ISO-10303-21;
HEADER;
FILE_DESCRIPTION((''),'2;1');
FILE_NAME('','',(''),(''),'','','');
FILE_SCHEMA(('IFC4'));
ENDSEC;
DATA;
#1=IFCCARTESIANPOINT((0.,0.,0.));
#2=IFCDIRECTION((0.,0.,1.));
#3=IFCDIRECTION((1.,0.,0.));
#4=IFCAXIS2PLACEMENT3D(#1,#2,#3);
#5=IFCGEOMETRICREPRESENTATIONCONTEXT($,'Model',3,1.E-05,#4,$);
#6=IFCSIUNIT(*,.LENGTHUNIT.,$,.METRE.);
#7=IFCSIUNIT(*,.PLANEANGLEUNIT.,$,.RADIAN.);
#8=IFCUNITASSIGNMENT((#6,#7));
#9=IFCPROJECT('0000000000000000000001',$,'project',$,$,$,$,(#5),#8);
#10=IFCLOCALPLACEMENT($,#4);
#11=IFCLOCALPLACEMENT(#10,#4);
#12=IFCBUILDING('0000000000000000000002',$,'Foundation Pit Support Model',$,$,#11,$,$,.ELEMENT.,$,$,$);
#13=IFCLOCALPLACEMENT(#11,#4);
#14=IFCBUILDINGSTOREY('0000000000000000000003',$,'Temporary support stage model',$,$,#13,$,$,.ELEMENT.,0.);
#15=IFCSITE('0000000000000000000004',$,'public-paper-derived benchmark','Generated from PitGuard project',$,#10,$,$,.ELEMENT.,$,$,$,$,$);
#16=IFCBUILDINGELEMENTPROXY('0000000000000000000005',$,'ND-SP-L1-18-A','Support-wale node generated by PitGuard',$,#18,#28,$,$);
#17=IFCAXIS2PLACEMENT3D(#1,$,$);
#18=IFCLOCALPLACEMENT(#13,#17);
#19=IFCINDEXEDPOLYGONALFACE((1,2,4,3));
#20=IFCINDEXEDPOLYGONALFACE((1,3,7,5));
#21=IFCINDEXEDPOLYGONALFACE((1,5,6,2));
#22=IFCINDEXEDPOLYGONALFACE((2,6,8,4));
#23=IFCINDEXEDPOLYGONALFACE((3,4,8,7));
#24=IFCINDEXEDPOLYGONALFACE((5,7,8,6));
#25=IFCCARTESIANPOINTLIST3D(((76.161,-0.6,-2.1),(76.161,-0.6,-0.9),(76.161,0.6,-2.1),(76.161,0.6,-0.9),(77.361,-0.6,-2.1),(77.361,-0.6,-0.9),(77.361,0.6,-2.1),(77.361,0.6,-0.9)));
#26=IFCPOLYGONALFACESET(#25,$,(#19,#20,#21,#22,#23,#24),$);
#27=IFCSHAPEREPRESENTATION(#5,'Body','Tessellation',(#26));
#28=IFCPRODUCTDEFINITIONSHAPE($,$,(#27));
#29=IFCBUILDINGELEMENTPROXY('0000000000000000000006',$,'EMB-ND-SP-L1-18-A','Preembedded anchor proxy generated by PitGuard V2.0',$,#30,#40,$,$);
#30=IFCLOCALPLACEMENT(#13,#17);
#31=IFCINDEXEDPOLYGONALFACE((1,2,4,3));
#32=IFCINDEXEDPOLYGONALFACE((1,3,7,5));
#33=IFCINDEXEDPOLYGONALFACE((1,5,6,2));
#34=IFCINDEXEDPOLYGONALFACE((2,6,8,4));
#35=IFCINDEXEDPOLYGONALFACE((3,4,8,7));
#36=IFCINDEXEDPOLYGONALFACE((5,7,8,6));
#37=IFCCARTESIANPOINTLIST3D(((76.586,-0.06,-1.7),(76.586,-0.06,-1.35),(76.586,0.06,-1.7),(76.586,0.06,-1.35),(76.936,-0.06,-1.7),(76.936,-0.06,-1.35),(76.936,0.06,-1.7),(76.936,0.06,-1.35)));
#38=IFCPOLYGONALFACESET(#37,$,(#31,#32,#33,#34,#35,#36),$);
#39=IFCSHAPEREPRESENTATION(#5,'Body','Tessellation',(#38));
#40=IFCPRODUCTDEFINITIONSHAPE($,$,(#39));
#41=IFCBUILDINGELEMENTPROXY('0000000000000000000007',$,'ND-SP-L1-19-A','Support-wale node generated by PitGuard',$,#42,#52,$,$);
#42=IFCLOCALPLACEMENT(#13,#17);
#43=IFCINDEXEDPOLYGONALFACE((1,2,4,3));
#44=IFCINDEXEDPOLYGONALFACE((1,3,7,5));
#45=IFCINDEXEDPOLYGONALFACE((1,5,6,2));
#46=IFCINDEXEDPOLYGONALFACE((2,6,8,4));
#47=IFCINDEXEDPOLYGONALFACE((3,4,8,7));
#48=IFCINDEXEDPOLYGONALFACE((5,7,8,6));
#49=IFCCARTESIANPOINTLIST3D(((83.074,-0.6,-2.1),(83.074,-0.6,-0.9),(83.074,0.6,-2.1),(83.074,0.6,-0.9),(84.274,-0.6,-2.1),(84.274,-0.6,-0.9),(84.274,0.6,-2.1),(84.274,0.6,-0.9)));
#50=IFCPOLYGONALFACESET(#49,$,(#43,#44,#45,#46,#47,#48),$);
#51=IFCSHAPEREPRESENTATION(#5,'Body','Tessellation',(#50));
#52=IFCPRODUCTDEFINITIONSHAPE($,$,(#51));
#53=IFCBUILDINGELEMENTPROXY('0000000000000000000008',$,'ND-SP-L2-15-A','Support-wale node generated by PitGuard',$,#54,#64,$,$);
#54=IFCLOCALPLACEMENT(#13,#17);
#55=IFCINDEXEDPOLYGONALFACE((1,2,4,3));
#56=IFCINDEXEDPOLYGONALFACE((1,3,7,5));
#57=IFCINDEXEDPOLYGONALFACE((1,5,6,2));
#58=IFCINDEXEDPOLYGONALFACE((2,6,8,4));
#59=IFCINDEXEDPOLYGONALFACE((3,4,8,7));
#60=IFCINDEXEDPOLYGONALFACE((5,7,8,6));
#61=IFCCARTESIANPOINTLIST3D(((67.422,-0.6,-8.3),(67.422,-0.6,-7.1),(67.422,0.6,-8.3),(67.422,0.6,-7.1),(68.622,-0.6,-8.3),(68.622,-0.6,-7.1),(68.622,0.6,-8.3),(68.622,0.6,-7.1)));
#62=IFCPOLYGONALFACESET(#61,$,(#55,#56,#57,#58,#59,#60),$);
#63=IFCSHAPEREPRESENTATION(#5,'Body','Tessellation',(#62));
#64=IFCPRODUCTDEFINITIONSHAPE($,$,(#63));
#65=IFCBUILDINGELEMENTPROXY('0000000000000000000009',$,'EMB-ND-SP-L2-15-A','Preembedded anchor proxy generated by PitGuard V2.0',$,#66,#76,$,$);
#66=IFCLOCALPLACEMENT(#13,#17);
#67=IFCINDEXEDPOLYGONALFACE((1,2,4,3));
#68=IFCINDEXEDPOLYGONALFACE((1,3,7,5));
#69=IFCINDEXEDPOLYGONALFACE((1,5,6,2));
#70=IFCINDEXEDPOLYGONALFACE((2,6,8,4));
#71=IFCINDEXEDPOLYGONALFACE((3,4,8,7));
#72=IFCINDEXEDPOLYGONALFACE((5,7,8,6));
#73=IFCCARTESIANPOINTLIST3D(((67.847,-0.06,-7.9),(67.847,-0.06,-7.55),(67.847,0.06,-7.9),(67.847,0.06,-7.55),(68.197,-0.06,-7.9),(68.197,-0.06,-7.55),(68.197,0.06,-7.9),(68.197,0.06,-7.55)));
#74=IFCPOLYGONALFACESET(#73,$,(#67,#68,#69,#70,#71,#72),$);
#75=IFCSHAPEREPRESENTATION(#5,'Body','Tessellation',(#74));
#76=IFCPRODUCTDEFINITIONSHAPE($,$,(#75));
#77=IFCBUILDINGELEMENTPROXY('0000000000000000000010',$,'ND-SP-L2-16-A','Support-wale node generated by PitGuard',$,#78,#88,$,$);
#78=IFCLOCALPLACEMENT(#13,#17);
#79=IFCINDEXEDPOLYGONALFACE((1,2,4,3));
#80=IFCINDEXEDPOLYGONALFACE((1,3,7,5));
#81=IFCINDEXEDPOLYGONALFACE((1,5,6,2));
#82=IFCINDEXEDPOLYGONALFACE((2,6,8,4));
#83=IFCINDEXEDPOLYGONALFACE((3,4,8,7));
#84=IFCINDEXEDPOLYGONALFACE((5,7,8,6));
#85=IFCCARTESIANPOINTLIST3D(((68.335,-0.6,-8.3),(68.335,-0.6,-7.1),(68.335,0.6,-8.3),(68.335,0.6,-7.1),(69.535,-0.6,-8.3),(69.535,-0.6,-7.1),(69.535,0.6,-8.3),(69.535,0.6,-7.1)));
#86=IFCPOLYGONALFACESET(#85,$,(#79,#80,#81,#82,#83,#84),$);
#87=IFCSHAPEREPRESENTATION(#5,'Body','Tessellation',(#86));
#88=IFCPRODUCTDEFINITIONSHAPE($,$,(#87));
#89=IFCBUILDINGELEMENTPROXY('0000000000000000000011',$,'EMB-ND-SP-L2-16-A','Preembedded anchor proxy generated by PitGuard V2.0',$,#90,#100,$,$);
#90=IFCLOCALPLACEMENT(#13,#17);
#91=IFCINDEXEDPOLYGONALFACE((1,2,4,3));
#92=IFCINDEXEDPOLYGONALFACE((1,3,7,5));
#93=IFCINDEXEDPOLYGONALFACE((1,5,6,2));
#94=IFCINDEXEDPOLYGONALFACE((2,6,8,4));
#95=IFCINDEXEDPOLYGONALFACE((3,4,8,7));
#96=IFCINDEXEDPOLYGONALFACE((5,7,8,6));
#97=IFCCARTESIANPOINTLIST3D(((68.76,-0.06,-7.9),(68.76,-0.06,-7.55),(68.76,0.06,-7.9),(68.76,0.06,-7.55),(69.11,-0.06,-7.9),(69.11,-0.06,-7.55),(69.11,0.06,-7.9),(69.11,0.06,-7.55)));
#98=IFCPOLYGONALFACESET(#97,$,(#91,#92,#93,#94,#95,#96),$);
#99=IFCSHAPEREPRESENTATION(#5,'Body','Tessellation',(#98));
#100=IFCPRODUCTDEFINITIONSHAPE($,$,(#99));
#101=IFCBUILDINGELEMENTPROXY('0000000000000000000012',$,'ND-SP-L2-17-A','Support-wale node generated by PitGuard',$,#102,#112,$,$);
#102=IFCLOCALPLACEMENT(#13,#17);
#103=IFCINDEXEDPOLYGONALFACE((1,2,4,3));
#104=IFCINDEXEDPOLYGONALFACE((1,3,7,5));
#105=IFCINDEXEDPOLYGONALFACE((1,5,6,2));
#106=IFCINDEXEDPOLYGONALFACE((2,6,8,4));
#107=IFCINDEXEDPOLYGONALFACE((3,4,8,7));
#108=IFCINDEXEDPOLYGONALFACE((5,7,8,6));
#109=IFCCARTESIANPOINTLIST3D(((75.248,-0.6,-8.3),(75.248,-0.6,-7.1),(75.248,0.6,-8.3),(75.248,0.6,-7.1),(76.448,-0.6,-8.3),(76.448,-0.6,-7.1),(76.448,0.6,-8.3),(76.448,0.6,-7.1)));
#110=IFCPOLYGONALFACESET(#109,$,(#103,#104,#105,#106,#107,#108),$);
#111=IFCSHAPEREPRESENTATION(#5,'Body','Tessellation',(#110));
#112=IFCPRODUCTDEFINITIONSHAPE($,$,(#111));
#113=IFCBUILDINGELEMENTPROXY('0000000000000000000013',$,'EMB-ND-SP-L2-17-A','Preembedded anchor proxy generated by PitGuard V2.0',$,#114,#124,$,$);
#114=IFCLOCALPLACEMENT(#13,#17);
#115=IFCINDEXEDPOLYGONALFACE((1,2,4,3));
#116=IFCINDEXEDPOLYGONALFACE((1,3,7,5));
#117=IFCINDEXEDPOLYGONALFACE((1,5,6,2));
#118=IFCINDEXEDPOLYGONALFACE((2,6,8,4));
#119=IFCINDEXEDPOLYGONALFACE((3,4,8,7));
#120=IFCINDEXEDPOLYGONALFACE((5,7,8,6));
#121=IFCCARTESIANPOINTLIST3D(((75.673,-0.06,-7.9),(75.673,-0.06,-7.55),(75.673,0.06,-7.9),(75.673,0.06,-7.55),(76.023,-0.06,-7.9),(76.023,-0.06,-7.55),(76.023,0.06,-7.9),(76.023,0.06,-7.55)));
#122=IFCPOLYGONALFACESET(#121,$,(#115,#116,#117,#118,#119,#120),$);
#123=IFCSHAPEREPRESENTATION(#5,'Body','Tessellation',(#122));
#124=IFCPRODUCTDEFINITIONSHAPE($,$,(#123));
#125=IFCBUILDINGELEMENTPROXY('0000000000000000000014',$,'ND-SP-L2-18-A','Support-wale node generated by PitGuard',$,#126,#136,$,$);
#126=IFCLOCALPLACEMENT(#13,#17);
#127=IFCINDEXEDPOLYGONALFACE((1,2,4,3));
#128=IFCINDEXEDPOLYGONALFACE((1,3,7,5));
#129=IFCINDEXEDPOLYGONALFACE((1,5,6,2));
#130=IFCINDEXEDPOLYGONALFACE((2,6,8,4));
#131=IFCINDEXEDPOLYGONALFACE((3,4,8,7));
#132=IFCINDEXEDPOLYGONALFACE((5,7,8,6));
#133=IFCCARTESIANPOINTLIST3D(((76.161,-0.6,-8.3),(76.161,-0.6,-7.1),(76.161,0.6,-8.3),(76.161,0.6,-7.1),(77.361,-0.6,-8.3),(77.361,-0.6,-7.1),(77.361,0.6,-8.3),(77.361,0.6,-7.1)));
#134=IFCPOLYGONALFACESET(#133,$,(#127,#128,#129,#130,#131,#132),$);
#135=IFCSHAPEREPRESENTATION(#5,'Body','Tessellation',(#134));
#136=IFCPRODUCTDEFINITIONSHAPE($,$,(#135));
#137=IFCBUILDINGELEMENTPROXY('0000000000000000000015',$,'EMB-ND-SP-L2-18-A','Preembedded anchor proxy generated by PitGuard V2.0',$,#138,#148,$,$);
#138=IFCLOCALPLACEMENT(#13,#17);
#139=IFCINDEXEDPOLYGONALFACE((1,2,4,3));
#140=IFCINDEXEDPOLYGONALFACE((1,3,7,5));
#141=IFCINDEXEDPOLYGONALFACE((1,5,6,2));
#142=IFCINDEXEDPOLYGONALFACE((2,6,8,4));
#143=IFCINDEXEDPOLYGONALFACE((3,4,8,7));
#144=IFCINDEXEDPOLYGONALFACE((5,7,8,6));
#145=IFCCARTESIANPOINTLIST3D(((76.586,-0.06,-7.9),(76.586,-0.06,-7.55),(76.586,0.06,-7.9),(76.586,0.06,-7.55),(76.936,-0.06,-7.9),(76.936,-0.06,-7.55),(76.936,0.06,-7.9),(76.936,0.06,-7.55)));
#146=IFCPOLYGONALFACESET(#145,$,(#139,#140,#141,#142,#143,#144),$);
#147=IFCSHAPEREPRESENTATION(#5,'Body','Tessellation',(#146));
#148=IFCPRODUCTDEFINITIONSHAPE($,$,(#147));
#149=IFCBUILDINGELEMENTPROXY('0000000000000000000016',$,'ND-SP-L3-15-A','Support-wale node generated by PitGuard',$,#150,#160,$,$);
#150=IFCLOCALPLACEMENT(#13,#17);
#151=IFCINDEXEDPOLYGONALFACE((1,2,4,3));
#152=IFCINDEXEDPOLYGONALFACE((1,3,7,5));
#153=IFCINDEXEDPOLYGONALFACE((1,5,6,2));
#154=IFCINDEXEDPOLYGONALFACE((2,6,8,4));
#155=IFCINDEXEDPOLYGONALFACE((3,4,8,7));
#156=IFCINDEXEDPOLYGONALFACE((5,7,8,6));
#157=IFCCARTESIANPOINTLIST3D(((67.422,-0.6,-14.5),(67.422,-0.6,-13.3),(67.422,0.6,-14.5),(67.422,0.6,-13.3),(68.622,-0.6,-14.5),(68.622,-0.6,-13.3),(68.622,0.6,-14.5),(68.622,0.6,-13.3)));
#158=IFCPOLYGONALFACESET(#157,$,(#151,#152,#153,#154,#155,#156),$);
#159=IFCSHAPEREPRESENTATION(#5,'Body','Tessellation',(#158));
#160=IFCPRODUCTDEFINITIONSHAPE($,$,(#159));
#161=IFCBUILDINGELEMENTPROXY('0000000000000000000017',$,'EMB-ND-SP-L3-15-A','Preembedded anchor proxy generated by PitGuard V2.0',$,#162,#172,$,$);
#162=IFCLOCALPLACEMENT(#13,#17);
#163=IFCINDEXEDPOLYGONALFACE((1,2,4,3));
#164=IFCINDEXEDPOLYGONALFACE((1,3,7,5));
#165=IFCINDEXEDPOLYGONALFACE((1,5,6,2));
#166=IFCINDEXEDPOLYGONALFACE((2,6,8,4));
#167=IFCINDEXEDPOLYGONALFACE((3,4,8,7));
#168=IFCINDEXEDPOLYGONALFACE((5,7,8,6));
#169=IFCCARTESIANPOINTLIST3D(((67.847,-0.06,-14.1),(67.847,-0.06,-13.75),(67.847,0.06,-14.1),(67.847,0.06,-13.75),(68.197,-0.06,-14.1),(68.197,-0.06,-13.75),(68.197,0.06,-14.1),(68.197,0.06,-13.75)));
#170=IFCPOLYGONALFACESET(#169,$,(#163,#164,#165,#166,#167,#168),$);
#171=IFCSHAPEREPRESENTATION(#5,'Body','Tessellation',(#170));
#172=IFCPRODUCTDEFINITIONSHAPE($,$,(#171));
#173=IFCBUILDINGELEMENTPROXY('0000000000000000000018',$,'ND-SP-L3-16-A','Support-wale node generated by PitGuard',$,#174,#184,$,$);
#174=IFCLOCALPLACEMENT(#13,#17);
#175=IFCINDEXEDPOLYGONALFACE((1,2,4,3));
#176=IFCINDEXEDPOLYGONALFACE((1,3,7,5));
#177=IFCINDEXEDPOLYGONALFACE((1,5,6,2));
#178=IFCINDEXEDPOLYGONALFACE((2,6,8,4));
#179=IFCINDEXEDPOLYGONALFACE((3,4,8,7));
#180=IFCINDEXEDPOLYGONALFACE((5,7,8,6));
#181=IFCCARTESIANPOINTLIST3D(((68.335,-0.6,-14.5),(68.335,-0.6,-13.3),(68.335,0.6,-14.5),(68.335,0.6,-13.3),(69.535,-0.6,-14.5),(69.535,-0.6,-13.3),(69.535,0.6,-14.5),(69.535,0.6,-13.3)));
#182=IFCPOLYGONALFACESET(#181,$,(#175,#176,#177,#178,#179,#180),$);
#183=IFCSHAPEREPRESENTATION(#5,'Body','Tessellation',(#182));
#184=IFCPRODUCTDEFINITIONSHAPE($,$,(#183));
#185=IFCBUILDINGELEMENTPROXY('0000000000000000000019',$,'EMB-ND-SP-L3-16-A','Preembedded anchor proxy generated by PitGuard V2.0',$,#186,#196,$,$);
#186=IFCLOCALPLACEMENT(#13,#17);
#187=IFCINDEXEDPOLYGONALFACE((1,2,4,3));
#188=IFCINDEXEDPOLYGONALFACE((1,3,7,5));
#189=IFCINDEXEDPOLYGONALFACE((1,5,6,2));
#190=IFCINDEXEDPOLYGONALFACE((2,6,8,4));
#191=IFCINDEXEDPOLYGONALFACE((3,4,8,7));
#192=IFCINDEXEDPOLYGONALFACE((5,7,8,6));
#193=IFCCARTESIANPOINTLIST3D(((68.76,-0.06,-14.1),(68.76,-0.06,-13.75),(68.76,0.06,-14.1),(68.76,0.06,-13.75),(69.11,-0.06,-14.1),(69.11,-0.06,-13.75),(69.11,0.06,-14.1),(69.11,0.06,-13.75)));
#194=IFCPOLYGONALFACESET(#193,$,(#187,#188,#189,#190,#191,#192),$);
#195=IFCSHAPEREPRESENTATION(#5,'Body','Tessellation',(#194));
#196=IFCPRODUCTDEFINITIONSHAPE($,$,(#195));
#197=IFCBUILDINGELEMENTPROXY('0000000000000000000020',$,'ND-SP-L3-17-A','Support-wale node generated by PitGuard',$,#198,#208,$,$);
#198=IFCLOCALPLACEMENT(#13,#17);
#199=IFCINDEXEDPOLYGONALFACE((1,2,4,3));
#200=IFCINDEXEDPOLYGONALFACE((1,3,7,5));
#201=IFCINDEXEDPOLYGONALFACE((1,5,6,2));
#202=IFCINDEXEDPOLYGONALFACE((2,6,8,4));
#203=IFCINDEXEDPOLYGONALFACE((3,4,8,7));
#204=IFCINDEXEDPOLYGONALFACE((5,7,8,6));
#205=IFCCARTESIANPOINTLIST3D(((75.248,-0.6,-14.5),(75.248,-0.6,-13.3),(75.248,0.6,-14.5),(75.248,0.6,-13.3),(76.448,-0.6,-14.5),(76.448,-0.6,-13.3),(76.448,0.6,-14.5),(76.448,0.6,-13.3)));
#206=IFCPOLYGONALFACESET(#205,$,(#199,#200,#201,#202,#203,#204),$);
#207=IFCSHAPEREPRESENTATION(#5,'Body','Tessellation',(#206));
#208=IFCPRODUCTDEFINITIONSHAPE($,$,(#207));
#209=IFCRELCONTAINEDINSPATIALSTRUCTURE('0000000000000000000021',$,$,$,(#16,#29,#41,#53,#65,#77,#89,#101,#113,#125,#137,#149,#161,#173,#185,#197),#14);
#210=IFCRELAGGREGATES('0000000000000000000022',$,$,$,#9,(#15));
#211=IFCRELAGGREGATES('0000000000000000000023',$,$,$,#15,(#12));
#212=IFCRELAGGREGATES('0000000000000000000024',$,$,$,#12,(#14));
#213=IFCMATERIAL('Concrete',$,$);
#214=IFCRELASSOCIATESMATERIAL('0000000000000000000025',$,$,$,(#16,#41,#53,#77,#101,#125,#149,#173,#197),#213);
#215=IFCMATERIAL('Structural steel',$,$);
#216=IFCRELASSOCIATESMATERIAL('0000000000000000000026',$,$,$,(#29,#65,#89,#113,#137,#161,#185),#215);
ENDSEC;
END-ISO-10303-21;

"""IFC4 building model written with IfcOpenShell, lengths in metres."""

from ifc_helpers import new_model, si_unit, frame, origin_with_axes, origin_2d, place, context, project, spatial, rectangle, extrude, material, element, save


model = new_model("IFC4")

# Units and contexts
model_context = context("Model", 3, precision=1e-05, world=origin_with_axes())
ifc_project = project(units=[si_unit("LENGTHUNIT", "METRE"), si_unit("PLANEANGLEUNIT", "RADIAN")], contexts=[model_context])

# Site, building, storey
site_placement = place(None, origin_with_axes())
site = spatial("IfcSite", under=ifc_project, at=site_placement, Name="public-paper-derived benchmark", Description="Generated from PitGuard project", CompositionType="ELEMENT")
building_placement = place(site_placement, origin_with_axes())
building = spatial("IfcBuilding", under=site, at=building_placement, Name="Foundation Pit Support Model", CompositionType="ELEMENT")
storey_placement = place(building_placement, origin_with_axes())
storey = spatial("IfcBuildingStorey", under=building, at=storey_placement, Name="Temporary support stage model", CompositionType="ELEMENT", Elevation=0.0)

# Shared definitions
ifc_material_1 = material(Name="Structural steel")

# Building element proxies
ifc_material_2 = material(Name="Concrete")
proxy_1_placement = place(storey_placement, frame((76.761, 0.0, -2.1), z_axis=(0.0, 0.0, 1.0), x_axis=(1.0, 0.0, 0.0)))
element("IfcBuildingElementProxy", 1, at=proxy_1_placement, inside=storey, material=ifc_material_2, Name="ND-SP-L1-18-A", Description="Support-wale node generated by PitGuard", context=model_context, shape_type="SweptSolid", body=[
    extrude(rectangle(XDim=1.2, YDim=1.2, at=origin_2d()), origin_with_axes(), (0.0, 0.0, 1.0), 1.2),
])
proxy_2_placement = place(storey_placement, frame((76.761, 0.0, -1.7), z_axis=(0.0, 0.0, 1.0), x_axis=(1.0, 0.0, 0.0)))
element("IfcBuildingElementProxy", 2, at=proxy_2_placement, inside=storey, material=ifc_material_1, Name="EMB-ND-SP-L1-18-A", Description="Preembedded anchor proxy generated by PitGuard V2.0", context=model_context, shape_type="SweptSolid", body=[
    extrude(rectangle(XDim=0.35, YDim=0.12, at=origin_2d()), origin_with_axes(), (0.0, 0.0, 1.0), 0.35),
])
for number, where, z_axis, x_axis, name in (
    (3, (83.674, 0.0, -2.1), (0.0, 0.0, 1.0), (1.0, 0.0, 0.0), "ND-SP-L1-19-A"),
    (4, (68.022, 0.0, -8.3), (0.0, 0.0, 1.0), (1.0, 0.0, 0.0), "ND-SP-L2-15-A"),
):
    element("IfcBuildingElementProxy", number, at=place(storey_placement, frame(where, z_axis=z_axis, x_axis=x_axis)), inside=storey, material=ifc_material_2, Name=name, Description="Support-wale node generated by PitGuard", context=model_context, shape_type="SweptSolid", body=[
        extrude(rectangle(XDim=1.2, YDim=1.2, at=origin_2d()), origin_with_axes(), (0.0, 0.0, 1.0), 1.2),
    ])
proxy_3_placement = place(storey_placement, frame((68.022, 0.0, -7.9), z_axis=(0.0, 0.0, 1.0), x_axis=(1.0, 0.0, 0.0)))
element("IfcBuildingElementProxy", 5, at=proxy_3_placement, inside=storey, material=ifc_material_1, Name="EMB-ND-SP-L2-15-A", Description="Preembedded anchor proxy generated by PitGuard V2.0", context=model_context, shape_type="SweptSolid", body=[
    extrude(rectangle(XDim=0.35, YDim=0.12, at=origin_2d()), origin_with_axes(), (0.0, 0.0, 1.0), 0.35),
])
proxy_4_placement = place(storey_placement, frame((68.935, 0.0, -8.3), z_axis=(0.0, 0.0, 1.0), x_axis=(1.0, 0.0, 0.0)))
element("IfcBuildingElementProxy", 6, at=proxy_4_placement, inside=storey, material=ifc_material_2, Name="ND-SP-L2-16-A", Description="Support-wale node generated by PitGuard", context=model_context, shape_type="SweptSolid", body=[
    extrude(rectangle(XDim=1.2, YDim=1.2, at=origin_2d()), origin_with_axes(), (0.0, 0.0, 1.0), 1.2),
])
proxy_5_placement = place(storey_placement, frame((68.935, 0.0, -7.9), z_axis=(0.0, 0.0, 1.0), x_axis=(1.0, 0.0, 0.0)))
element("IfcBuildingElementProxy", 7, at=proxy_5_placement, inside=storey, material=ifc_material_1, Name="EMB-ND-SP-L2-16-A", Description="Preembedded anchor proxy generated by PitGuard V2.0", context=model_context, shape_type="SweptSolid", body=[
    extrude(rectangle(XDim=0.35, YDim=0.12, at=origin_2d()), origin_with_axes(), (0.0, 0.0, 1.0), 0.35),
])
proxy_6_placement = place(storey_placement, frame((75.848, 0.0, -8.3), z_axis=(0.0, 0.0, 1.0), x_axis=(1.0, 0.0, 0.0)))
element("IfcBuildingElementProxy", 8, at=proxy_6_placement, inside=storey, material=ifc_material_2, Name="ND-SP-L2-17-A", Description="Support-wale node generated by PitGuard", context=model_context, shape_type="SweptSolid", body=[
    extrude(rectangle(XDim=1.2, YDim=1.2, at=origin_2d()), origin_with_axes(), (0.0, 0.0, 1.0), 1.2),
])
proxy_7_placement = place(storey_placement, frame((75.848, 0.0, -7.9), z_axis=(0.0, 0.0, 1.0), x_axis=(1.0, 0.0, 0.0)))
element("IfcBuildingElementProxy", 9, at=proxy_7_placement, inside=storey, material=ifc_material_1, Name="EMB-ND-SP-L2-17-A", Description="Preembedded anchor proxy generated by PitGuard V2.0", context=model_context, shape_type="SweptSolid", body=[
    extrude(rectangle(XDim=0.35, YDim=0.12, at=origin_2d()), origin_with_axes(), (0.0, 0.0, 1.0), 0.35),
])
proxy_8_placement = place(storey_placement, frame((76.761, 0.0, -8.3), z_axis=(0.0, 0.0, 1.0), x_axis=(1.0, 0.0, 0.0)))
element("IfcBuildingElementProxy", 10, at=proxy_8_placement, inside=storey, material=ifc_material_2, Name="ND-SP-L2-18-A", Description="Support-wale node generated by PitGuard", context=model_context, shape_type="SweptSolid", body=[
    extrude(rectangle(XDim=1.2, YDim=1.2, at=origin_2d()), origin_with_axes(), (0.0, 0.0, 1.0), 1.2),
])
proxy_9_placement = place(storey_placement, frame((76.761, 0.0, -7.9), z_axis=(0.0, 0.0, 1.0), x_axis=(1.0, 0.0, 0.0)))
element("IfcBuildingElementProxy", 11, at=proxy_9_placement, inside=storey, material=ifc_material_1, Name="EMB-ND-SP-L2-18-A", Description="Preembedded anchor proxy generated by PitGuard V2.0", context=model_context, shape_type="SweptSolid", body=[
    extrude(rectangle(XDim=0.35, YDim=0.12, at=origin_2d()), origin_with_axes(), (0.0, 0.0, 1.0), 0.35),
])
proxy_10_placement = place(storey_placement, frame((68.022, 0.0, -14.5), z_axis=(0.0, 0.0, 1.0), x_axis=(1.0, 0.0, 0.0)))
element("IfcBuildingElementProxy", 12, at=proxy_10_placement, inside=storey, material=ifc_material_2, Name="ND-SP-L3-15-A", Description="Support-wale node generated by PitGuard", context=model_context, shape_type="SweptSolid", body=[
    extrude(rectangle(XDim=1.2, YDim=1.2, at=origin_2d()), origin_with_axes(), (0.0, 0.0, 1.0), 1.2),
])
proxy_11_placement = place(storey_placement, frame((68.022, 0.0, -14.1), z_axis=(0.0, 0.0, 1.0), x_axis=(1.0, 0.0, 0.0)))
element("IfcBuildingElementProxy", 13, at=proxy_11_placement, inside=storey, material=ifc_material_1, Name="EMB-ND-SP-L3-15-A", Description="Preembedded anchor proxy generated by PitGuard V2.0", context=model_context, shape_type="SweptSolid", body=[
    extrude(rectangle(XDim=0.35, YDim=0.12, at=origin_2d()), origin_with_axes(), (0.0, 0.0, 1.0), 0.35),
])
proxy_12_placement = place(storey_placement, frame((68.935, 0.0, -14.5), z_axis=(0.0, 0.0, 1.0), x_axis=(1.0, 0.0, 0.0)))
element("IfcBuildingElementProxy", 14, at=proxy_12_placement, inside=storey, material=ifc_material_2, Name="ND-SP-L3-16-A", Description="Support-wale node generated by PitGuard", context=model_context, shape_type="SweptSolid", body=[
    extrude(rectangle(XDim=1.2, YDim=1.2, at=origin_2d()), origin_with_axes(), (0.0, 0.0, 1.0), 1.2),
])
proxy_13_placement = place(storey_placement, frame((68.935, 0.0, -14.1), z_axis=(0.0, 0.0, 1.0), x_axis=(1.0, 0.0, 0.0)))
element("IfcBuildingElementProxy", 15, at=proxy_13_placement, inside=storey, material=ifc_material_1, Name="EMB-ND-SP-L3-16-A", Description="Preembedded anchor proxy generated by PitGuard V2.0", context=model_context, shape_type="SweptSolid", body=[
    extrude(rectangle(XDim=0.35, YDim=0.12, at=origin_2d()), origin_with_axes(), (0.0, 0.0, 1.0), 0.35),
])
proxy_14_placement = place(storey_placement, frame((75.848, 0.0, -14.5), z_axis=(0.0, 0.0, 1.0), x_axis=(1.0, 0.0, 0.0)))
element("IfcBuildingElementProxy", 16, at=proxy_14_placement, inside=storey, material=ifc_material_2, Name="ND-SP-L3-17-A", Description="Support-wale node generated by PitGuard", context=model_context, shape_type="SweptSolid", body=[
    extrude(rectangle(XDim=1.2, YDim=1.2, at=origin_2d()), origin_with_axes(), (0.0, 0.0, 1.0), 1.2),
])

save(model, "model.ifc")
